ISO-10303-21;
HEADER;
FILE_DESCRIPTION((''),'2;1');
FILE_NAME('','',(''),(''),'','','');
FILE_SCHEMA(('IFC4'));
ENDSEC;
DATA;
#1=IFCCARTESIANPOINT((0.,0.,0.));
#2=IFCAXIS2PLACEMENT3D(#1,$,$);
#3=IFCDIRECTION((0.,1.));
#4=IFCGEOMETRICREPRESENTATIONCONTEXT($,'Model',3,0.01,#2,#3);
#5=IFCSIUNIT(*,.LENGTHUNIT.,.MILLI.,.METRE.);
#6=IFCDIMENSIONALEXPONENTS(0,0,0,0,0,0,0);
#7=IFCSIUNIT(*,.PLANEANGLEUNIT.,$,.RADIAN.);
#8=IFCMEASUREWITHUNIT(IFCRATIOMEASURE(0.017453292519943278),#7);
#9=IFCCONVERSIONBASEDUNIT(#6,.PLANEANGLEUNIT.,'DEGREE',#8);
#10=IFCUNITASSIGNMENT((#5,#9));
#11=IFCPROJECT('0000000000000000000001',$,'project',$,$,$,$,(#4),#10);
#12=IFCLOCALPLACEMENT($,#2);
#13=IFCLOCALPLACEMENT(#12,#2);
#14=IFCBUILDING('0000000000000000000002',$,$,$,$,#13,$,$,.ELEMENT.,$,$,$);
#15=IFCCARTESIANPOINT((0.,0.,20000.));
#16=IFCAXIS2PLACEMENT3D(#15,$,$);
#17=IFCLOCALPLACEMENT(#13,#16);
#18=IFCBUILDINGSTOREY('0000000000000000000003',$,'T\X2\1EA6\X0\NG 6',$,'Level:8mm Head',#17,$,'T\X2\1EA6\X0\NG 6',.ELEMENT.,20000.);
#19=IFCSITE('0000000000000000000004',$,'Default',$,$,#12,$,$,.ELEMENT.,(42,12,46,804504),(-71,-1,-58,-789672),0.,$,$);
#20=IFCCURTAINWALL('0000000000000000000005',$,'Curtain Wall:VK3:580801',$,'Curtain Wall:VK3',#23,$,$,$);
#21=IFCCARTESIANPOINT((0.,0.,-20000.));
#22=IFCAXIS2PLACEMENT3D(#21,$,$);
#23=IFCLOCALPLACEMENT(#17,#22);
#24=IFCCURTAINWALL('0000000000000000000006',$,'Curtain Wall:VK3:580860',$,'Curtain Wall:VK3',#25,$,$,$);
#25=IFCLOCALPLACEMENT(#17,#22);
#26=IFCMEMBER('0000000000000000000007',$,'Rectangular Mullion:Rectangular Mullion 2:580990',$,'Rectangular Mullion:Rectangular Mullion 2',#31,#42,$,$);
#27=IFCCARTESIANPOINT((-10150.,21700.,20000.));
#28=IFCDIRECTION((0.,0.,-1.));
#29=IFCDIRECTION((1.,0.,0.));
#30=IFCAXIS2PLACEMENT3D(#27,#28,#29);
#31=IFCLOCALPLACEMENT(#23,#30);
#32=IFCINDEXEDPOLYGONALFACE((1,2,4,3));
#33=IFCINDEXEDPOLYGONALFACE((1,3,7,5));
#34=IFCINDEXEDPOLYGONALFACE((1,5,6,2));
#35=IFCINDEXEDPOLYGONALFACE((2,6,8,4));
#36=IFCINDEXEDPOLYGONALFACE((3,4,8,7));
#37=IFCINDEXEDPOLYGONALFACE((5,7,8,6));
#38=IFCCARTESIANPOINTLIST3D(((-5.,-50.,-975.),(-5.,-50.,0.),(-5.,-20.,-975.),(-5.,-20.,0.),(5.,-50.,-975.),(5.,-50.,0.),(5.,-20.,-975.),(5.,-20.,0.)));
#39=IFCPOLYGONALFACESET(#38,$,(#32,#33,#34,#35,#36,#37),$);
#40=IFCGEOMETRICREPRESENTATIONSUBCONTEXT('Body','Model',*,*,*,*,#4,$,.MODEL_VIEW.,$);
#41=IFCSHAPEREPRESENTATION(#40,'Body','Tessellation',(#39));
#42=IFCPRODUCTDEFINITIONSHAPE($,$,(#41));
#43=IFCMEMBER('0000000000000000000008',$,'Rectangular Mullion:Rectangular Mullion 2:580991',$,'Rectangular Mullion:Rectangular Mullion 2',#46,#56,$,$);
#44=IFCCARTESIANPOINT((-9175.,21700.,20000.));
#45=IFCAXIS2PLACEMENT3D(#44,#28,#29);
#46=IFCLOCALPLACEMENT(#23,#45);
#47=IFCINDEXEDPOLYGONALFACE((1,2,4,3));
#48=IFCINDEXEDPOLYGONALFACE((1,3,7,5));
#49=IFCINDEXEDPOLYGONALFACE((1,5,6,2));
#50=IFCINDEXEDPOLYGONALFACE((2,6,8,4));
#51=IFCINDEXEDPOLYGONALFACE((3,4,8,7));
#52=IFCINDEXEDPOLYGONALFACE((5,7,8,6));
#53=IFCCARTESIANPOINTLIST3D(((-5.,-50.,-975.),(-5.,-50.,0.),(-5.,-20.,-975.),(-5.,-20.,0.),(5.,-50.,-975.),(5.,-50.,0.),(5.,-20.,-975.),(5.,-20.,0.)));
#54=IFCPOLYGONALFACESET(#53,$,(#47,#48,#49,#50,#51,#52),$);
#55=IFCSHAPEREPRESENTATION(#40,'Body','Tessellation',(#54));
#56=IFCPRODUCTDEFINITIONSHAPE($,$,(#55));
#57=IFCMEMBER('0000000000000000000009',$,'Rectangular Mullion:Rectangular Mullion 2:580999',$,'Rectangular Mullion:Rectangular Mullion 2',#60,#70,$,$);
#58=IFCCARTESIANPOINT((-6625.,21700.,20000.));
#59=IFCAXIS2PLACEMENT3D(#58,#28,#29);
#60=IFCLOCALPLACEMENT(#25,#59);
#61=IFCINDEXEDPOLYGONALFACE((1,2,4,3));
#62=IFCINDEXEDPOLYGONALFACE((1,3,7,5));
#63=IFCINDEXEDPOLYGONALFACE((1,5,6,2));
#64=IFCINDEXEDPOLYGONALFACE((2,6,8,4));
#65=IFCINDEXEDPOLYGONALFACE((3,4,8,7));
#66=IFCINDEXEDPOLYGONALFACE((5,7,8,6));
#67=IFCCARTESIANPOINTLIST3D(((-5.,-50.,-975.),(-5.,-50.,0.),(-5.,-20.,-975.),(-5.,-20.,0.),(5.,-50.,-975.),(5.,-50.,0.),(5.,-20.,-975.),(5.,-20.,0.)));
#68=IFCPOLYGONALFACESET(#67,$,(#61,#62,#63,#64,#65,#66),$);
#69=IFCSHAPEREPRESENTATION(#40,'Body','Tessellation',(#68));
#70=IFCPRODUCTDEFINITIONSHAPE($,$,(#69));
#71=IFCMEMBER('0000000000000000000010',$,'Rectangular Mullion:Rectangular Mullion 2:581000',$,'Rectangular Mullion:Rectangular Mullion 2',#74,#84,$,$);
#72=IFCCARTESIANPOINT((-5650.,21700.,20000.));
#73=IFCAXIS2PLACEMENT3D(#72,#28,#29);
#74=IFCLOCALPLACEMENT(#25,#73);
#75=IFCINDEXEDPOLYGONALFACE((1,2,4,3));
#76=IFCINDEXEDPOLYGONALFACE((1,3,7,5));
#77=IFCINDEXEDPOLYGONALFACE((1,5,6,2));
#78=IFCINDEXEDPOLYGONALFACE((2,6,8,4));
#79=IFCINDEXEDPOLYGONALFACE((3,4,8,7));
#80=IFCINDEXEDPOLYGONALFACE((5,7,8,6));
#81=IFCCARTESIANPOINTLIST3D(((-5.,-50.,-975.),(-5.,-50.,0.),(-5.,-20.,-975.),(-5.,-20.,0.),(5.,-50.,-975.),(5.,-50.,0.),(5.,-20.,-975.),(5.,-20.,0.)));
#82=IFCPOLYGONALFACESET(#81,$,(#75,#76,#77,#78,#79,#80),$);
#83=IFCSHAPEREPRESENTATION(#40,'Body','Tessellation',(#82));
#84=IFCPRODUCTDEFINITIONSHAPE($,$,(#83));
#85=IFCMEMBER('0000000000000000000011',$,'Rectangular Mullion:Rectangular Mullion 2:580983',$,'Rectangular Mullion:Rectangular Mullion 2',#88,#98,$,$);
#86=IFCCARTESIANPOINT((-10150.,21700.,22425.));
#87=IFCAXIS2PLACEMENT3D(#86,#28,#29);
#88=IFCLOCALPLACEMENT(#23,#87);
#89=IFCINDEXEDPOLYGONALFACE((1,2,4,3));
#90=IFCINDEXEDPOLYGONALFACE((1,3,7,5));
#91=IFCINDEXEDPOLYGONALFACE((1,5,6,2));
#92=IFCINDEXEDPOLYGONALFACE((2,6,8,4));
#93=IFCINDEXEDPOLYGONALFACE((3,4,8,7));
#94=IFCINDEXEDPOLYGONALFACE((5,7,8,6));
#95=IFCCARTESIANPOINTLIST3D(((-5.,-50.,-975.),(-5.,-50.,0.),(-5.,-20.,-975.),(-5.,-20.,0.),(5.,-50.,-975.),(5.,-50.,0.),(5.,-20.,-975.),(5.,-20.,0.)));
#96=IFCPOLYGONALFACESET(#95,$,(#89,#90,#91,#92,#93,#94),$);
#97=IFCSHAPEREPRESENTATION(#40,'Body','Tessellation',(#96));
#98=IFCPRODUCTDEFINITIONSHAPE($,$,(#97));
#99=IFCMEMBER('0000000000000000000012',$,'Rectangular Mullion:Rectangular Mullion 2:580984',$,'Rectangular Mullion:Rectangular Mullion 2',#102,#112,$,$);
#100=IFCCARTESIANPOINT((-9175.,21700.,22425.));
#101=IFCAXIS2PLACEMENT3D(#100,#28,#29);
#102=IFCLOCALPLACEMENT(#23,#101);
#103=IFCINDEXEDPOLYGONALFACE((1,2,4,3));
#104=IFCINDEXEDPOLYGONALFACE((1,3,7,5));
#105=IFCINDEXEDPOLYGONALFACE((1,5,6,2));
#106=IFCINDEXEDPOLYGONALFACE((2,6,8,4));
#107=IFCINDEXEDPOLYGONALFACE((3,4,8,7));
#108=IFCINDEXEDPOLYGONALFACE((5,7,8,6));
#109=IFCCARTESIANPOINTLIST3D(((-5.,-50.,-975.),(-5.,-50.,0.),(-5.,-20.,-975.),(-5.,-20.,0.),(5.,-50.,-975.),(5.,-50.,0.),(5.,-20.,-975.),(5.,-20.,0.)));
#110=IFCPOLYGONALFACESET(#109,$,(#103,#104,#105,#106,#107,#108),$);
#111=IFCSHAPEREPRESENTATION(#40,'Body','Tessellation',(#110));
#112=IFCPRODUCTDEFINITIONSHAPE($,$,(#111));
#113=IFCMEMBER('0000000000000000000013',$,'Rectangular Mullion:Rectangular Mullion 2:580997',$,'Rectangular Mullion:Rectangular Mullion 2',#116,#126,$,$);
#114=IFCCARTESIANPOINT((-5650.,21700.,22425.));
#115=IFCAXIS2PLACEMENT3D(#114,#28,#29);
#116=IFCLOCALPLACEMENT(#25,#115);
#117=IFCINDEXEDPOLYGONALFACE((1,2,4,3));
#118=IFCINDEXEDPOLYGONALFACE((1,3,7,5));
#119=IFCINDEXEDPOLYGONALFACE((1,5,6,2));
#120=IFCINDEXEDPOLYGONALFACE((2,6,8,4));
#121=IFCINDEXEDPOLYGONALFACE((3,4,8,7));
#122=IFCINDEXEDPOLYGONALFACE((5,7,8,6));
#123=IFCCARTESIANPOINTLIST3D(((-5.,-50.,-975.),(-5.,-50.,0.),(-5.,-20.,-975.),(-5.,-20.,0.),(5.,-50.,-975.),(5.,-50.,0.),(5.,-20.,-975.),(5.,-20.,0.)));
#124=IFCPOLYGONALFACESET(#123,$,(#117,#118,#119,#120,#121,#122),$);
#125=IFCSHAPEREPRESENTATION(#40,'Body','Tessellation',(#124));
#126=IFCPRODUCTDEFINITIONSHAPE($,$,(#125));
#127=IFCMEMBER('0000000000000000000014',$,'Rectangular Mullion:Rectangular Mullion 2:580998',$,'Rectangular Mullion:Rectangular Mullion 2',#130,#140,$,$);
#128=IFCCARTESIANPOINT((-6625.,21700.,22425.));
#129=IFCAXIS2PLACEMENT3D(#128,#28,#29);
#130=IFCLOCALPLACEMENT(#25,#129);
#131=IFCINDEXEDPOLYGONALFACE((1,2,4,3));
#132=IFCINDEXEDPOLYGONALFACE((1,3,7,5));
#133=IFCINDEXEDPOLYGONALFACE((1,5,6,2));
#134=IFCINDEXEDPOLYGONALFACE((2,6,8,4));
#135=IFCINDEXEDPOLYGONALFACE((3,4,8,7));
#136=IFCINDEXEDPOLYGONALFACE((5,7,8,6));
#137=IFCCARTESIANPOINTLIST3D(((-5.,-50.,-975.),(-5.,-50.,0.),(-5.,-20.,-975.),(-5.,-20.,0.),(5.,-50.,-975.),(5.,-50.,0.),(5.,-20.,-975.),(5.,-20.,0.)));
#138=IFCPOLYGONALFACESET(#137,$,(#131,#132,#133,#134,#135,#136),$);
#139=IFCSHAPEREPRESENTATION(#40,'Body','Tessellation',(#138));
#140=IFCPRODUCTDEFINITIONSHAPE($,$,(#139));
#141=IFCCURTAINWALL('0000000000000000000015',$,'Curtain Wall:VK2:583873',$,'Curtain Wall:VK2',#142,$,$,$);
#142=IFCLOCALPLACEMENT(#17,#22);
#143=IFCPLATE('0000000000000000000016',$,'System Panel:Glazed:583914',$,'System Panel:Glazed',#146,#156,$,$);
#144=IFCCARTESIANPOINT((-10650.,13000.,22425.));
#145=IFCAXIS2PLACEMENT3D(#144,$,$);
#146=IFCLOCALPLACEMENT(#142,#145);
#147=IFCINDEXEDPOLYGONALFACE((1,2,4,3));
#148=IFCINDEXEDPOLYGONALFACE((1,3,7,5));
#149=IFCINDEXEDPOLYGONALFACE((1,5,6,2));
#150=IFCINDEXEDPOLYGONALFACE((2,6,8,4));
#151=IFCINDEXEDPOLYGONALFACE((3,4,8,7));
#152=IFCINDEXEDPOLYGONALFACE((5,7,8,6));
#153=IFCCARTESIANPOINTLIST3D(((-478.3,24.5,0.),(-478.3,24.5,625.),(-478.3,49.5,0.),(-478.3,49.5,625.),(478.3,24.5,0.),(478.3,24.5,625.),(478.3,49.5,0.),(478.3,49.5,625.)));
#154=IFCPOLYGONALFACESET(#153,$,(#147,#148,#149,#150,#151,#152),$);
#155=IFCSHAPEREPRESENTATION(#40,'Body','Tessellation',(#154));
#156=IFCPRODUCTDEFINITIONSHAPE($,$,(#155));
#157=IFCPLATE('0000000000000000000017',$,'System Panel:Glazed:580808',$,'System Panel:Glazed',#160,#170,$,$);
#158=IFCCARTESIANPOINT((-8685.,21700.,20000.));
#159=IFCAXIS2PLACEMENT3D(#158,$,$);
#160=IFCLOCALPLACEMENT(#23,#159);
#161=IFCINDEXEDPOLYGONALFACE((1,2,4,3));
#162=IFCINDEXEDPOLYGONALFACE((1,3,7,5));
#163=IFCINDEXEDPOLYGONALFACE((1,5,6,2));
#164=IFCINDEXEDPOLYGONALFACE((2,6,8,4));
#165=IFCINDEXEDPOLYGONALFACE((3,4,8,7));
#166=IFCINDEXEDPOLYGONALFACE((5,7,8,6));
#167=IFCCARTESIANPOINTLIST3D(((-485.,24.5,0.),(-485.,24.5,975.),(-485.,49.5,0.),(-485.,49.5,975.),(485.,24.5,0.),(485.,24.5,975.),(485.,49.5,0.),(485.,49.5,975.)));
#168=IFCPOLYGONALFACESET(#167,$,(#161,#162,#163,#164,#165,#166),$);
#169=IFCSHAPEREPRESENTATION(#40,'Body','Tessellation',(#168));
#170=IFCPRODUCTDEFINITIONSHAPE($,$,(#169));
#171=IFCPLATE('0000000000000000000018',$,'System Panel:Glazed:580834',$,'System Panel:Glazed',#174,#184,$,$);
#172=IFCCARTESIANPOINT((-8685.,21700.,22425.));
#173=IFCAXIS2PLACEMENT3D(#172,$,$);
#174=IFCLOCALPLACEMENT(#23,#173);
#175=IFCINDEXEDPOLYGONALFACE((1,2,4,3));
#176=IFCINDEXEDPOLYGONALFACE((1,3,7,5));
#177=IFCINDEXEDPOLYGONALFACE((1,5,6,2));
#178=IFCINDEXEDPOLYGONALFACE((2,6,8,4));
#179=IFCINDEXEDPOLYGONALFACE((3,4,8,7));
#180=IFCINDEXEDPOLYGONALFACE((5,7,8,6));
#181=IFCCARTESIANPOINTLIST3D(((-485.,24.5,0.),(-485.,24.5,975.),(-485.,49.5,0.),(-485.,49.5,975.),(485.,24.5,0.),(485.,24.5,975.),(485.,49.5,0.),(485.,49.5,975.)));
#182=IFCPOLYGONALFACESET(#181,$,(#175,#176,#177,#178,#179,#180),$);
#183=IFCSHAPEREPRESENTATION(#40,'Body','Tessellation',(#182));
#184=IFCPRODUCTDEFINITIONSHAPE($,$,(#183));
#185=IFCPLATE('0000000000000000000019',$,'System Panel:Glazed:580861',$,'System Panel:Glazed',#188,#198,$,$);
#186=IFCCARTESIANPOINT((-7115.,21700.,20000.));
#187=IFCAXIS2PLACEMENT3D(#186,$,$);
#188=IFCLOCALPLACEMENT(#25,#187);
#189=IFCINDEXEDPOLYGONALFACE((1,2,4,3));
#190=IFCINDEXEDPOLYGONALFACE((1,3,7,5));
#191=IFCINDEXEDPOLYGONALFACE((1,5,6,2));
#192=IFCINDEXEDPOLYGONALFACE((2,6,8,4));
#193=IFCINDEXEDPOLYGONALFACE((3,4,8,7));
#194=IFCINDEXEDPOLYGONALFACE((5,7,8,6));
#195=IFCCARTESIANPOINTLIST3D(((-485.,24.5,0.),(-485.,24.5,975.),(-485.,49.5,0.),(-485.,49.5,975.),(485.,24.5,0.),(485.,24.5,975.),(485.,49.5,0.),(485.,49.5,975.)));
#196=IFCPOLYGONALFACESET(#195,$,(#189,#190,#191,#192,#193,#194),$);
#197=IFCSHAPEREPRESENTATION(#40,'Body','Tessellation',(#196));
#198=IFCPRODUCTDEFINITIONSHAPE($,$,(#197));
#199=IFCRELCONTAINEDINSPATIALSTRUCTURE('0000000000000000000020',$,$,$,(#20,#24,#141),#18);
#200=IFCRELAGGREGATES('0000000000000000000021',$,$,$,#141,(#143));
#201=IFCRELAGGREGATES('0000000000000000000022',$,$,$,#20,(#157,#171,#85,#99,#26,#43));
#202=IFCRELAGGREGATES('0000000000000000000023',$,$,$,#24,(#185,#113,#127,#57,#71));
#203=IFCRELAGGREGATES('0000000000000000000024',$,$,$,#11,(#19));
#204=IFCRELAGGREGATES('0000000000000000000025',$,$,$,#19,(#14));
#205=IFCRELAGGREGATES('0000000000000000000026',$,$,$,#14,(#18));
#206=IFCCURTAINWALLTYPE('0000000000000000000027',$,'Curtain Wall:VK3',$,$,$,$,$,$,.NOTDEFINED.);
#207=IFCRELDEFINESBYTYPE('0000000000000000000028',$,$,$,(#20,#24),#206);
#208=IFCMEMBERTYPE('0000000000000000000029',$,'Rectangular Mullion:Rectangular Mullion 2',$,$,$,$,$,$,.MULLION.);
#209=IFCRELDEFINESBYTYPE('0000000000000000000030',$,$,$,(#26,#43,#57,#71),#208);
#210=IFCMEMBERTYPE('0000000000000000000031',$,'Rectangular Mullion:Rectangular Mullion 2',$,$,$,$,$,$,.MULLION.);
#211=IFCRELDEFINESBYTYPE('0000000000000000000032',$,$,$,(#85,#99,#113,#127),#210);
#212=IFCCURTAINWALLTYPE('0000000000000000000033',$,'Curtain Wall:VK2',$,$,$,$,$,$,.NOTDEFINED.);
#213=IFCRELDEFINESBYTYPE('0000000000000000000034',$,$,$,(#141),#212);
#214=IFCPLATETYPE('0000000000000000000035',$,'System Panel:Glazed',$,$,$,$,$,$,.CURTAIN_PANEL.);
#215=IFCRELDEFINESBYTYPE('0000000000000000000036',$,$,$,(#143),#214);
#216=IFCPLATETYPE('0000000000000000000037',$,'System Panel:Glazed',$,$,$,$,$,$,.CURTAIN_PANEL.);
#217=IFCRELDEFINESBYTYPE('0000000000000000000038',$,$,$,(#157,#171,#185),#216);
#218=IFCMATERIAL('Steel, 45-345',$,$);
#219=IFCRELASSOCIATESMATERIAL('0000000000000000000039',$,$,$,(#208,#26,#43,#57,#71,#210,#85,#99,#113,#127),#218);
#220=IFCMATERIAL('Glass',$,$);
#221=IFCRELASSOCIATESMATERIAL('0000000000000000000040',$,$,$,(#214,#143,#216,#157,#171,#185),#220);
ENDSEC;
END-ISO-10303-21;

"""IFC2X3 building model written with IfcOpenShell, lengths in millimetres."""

from ifc_helpers import new_model, entity, si_unit, converted_unit, direction, frame, frame_2d, origin, origin_2d_with_axis, place, context, subcontext, project, spatial, rectangle, extrude, source, transform, mapped, material, type_object, type_shapes, element, aggregate, save


model = new_model("IFC2X3")

# Units and contexts
model_context = context("Model", 3, precision=0.01, world=origin(), true_north=direction((0.0, 1.0)))
body_context = subcontext(model_context, "Body", "Model", "MODEL_VIEW")
ifc_project = project(units=[si_unit("LENGTHUNIT", "METRE", prefix="MILLI"), converted_unit("PLANEANGLEUNIT", "DEGREE", entity("IfcRatioMeasure", 0.017453292519943278), si_unit("PLANEANGLEUNIT", "RADIAN"), dimensions=[0, 0, 0, 0, 0, 0, 0])], contexts=[model_context])

# Site, building, storey
site_placement = place(None, origin())
site = spatial("IfcSite", under=ifc_project, at=site_placement, Name="Default", CompositionType="ELEMENT", RefLatitude=(42, 12, 46, 804504), RefLongitude=(-71, -1, -58, -789672), RefElevation=0.0)
building_placement = place(site_placement, origin())
building = spatial("IfcBuilding", under=site, at=building_placement, CompositionType="ELEMENT")
storey_placement = place(building_placement, frame((0.0, 0.0, 20000.0)))
storey = spatial("IfcBuildingStorey", under=building, at=storey_placement, Name="TẦNG 6", ObjectType="Level:8mm Head", LongName="TẦNG 6", CompositionType="ELEMENT", Elevation=20000.0)

# Curtain walls
curtain_wall_type_1 = type_object("IfcCurtainWallType", Name="Curtain Wall:VK3", PredefinedType="NOTDEFINED")
curtain_wall_1_placement = place(storey_placement, frame((0.0, 0.0, -20000.0)))
curtain_wall_1 = element("IfcCurtainWall", 1, at=curtain_wall_1_placement, inside=storey, type_object=curtain_wall_type_1, Name="Curtain Wall:VK3:580801", ObjectType="Curtain Wall:VK3")
ifc_material_1 = material(Name="Steel, 45-345")
curtain_wall_2_placement = place(storey_placement, frame((0.0, 0.0, -20000.0)))
curtain_wall_2 = element("IfcCurtainWall", 2, at=curtain_wall_2_placement, inside=storey, type_object=curtain_wall_type_1, Name="Curtain Wall:VK3:580860", ObjectType="Curtain Wall:VK3")

# Members
member_type_1 = type_object("IfcMemberType", Name="Rectangular Mullion:Rectangular Mullion 2", PredefinedType="MULLION", material=ifc_material_1)
shared_shape_1 = source(origin(), body_context, "Body", "SweptSolid", [
    extrude(rectangle(XDim=30.0, YDim=10.0, at=frame_2d((0.0, 0.0), x_axis=(1.0, 0.0))), frame((0.0, -35.0, -975.0), z_axis=(0.0, 0.0, 1.0), x_axis=(0.0, -1.0, 0.0)), (0.0, 0.0, 1.0), 975.0),
])
type_shapes(member_type_1, [shared_shape_1])
member_1_placement = place(curtain_wall_1_placement, frame((-10150.0, 21700.0, 20000.0), z_axis=(0.0, 0.0, -1.0), x_axis=(1.0, 0.0, 0.0)))
member_1 = element("IfcMember", 3, at=member_1_placement, type_object=member_type_1, material=ifc_material_1, Name="Rectangular Mullion:Rectangular Mullion 2:580990", ObjectType="Rectangular Mullion:Rectangular Mullion 2", context=body_context, shape_type="MappedRepresentation", body=[
    mapped(shared_shape_1, transform((0.0, 0.0, 0.0), scale=1.0)),
])
member_2_placement = place(curtain_wall_1_placement, frame((-9175.0, 21700.0, 20000.0), z_axis=(0.0, 0.0, -1.0), x_axis=(1.0, 0.0, 0.0)))
member_2 = element("IfcMember", 4, at=member_2_placement, type_object=member_type_1, material=ifc_material_1, Name="Rectangular Mullion:Rectangular Mullion 2:580991", ObjectType="Rectangular Mullion:Rectangular Mullion 2", context=body_context, shape_type="MappedRepresentation", body=[
    mapped(shared_shape_1, transform((0.0, 0.0, 0.0), scale=1.0)),
])
member_3_placement = place(curtain_wall_2_placement, frame((-6625.0, 21700.0, 20000.0), z_axis=(0.0, 0.0, -1.0), x_axis=(1.0, 0.0, 0.0)))
member_3 = element("IfcMember", 5, at=member_3_placement, type_object=member_type_1, material=ifc_material_1, Name="Rectangular Mullion:Rectangular Mullion 2:580999", ObjectType="Rectangular Mullion:Rectangular Mullion 2", context=body_context, shape_type="MappedRepresentation", body=[
    mapped(shared_shape_1, transform((0.0, 0.0, 0.0), scale=1.0)),
])
member_4_placement = place(curtain_wall_2_placement, frame((-5650.0, 21700.0, 20000.0), z_axis=(0.0, 0.0, -1.0), x_axis=(1.0, 0.0, 0.0)))
member_4 = element("IfcMember", 6, at=member_4_placement, type_object=member_type_1, material=ifc_material_1, Name="Rectangular Mullion:Rectangular Mullion 2:581000", ObjectType="Rectangular Mullion:Rectangular Mullion 2", context=body_context, shape_type="MappedRepresentation", body=[
    mapped(shared_shape_1, transform((0.0, 0.0, 0.0), scale=1.0)),
])
member_type_2 = type_object("IfcMemberType", Name="Rectangular Mullion:Rectangular Mullion 2", PredefinedType="MULLION", material=ifc_material_1)
shared_shape_2 = source(origin(), body_context, "Body", "SweptSolid", [
    extrude(rectangle(XDim=30.0, YDim=10.0, at=frame_2d((0.0, 0.0), x_axis=(1.0, 0.0))), frame((0.0, -35.0, -975.0), z_axis=(0.0, 0.0, 1.0), x_axis=(0.0, -1.0, 0.0)), (0.0, 0.0, 1.0), 975.0),
])
type_shapes(member_type_2, [shared_shape_2])
member_5_placement = place(curtain_wall_1_placement, frame((-10150.0, 21700.0, 22425.0), z_axis=(0.0, 0.0, -1.0), x_axis=(1.0, 0.0, 0.0)))
member_5 = element("IfcMember", 7, at=member_5_placement, type_object=member_type_2, material=ifc_material_1, Name="Rectangular Mullion:Rectangular Mullion 2:580983", ObjectType="Rectangular Mullion:Rectangular Mullion 2", context=body_context, shape_type="MappedRepresentation", body=[
    mapped(shared_shape_2, transform((0.0, 0.0, 0.0), scale=1.0)),
])
member_6_placement = place(curtain_wall_1_placement, frame((-9175.0, 21700.0, 22425.0), z_axis=(0.0, 0.0, -1.0), x_axis=(1.0, 0.0, 0.0)))
member_6 = element("IfcMember", 8, at=member_6_placement, type_object=member_type_2, material=ifc_material_1, Name="Rectangular Mullion:Rectangular Mullion 2:580984", ObjectType="Rectangular Mullion:Rectangular Mullion 2", context=body_context, shape_type="MappedRepresentation", body=[
    mapped(shared_shape_2, transform((0.0, 0.0, 0.0), scale=1.0)),
])
member_7_placement = place(curtain_wall_2_placement, frame((-5650.0, 21700.0, 22425.0), z_axis=(0.0, 0.0, -1.0), x_axis=(1.0, 0.0, 0.0)))
member_7 = element("IfcMember", 9, at=member_7_placement, type_object=member_type_2, material=ifc_material_1, Name="Rectangular Mullion:Rectangular Mullion 2:580997", ObjectType="Rectangular Mullion:Rectangular Mullion 2", context=body_context, shape_type="MappedRepresentation", body=[
    mapped(shared_shape_2, transform((0.0, 0.0, 0.0), scale=1.0)),
])
member_8_placement = place(curtain_wall_2_placement, frame((-6625.0, 21700.0, 22425.0), z_axis=(0.0, 0.0, -1.0), x_axis=(1.0, 0.0, 0.0)))
member_8 = element("IfcMember", 10, at=member_8_placement, type_object=member_type_2, material=ifc_material_1, Name="Rectangular Mullion:Rectangular Mullion 2:580998", ObjectType="Rectangular Mullion:Rectangular Mullion 2", context=body_context, shape_type="MappedRepresentation", body=[
    mapped(shared_shape_2, transform((0.0, 0.0, 0.0), scale=1.0)),
])

# Curtain wall, plate
curtain_wall_type_2 = type_object("IfcCurtainWallType", Name="Curtain Wall:VK2", PredefinedType="NOTDEFINED")
curtain_wall_3_placement = place(storey_placement, frame((0.0, 0.0, -20000.0)))
curtain_wall_3 = element("IfcCurtainWall", 11, at=curtain_wall_3_placement, inside=storey, type_object=curtain_wall_type_2, Name="Curtain Wall:VK2:583873", ObjectType="Curtain Wall:VK2")
ifc_material_2 = material(Name="Glass")
plate_type_1 = type_object("IfcPlateType", Name="System Panel:Glazed", PredefinedType="CURTAIN_PANEL", material=ifc_material_2)
shared_shape_3 = source(origin(), body_context, "Body", "SweptSolid", [
    extrude(rectangle(XDim=25.0, YDim=956.7, at=frame_2d((0.0, 0.0), x_axis=(1.0, 0.0))), frame((0.0, 37.0, 0.0), z_axis=(0.0, 0.0, 1.0), x_axis=(0.0, 1.0, 0.0)), (0.0, 0.0, 1.0), 625.0),
])
type_shapes(plate_type_1, [shared_shape_3])
plate_1_placement = place(curtain_wall_3_placement, frame((-10650.0, 13000.0, 22425.0)))
plate_1 = element("IfcPlate", 12, at=plate_1_placement, type_object=plate_type_1, material=ifc_material_2, Name="System Panel:Glazed:583914", ObjectType="System Panel:Glazed", context=body_context, shape_type="MappedRepresentation", body=[
    mapped(shared_shape_3, transform((0.0, 0.0, 0.0), scale=1.0)),
])
aggregate(curtain_wall_3, [plate_1])

# Plates
plate_type_2 = type_object("IfcPlateType", Name="System Panel:Glazed", PredefinedType="CURTAIN_PANEL", material=ifc_material_2)
shared_shape_4 = source(origin(), body_context, "Body", "SweptSolid", [
    extrude(rectangle(XDim=25.0, YDim=970.0, at=origin_2d_with_axis()), frame((0.0, 37.0, 0.0), z_axis=(0.0, 0.0, 1.0), x_axis=(0.0, 1.0, 0.0)), (0.0, 0.0, 1.0), 975.0),
])
type_shapes(plate_type_2, [shared_shape_4])
plate_2_placement = place(curtain_wall_1_placement, frame((-8685.0, 21700.0, 20000.0)))
plate_2 = element("IfcPlate", 13, at=plate_2_placement, type_object=plate_type_2, material=ifc_material_2, Name="System Panel:Glazed:580808", ObjectType="System Panel:Glazed", context=body_context, shape_type="MappedRepresentation", body=[
    mapped(shared_shape_4, transform((0.0, 0.0, 0.0), scale=1.0)),
])
plate_3_placement = place(curtain_wall_1_placement, frame((-8685.0, 21700.0, 22425.0)))
plate_3 = element("IfcPlate", 14, at=plate_3_placement, type_object=plate_type_2, material=ifc_material_2, Name="System Panel:Glazed:580834", ObjectType="System Panel:Glazed", context=body_context, shape_type="MappedRepresentation", body=[
    mapped(shared_shape_4, transform((0.0, 0.0, 0.0), scale=1.0)),
])
plate_4_placement = place(curtain_wall_2_placement, frame((-7115.0, 21700.0, 20000.0)))
plate_4 = element("IfcPlate", 15, at=plate_4_placement, type_object=plate_type_2, material=ifc_material_2, Name="System Panel:Glazed:580861", ObjectType="System Panel:Glazed", context=body_context, shape_type="MappedRepresentation", body=[
    mapped(shared_shape_4, transform((0.0, 0.0, 0.0), scale=1.0)),
])
aggregate(curtain_wall_1, [plate_2, plate_3, member_5, member_6, member_1, member_2])
aggregate(curtain_wall_2, [plate_4, member_7, member_8, member_3, member_4])

save(model, "model.ifc")
